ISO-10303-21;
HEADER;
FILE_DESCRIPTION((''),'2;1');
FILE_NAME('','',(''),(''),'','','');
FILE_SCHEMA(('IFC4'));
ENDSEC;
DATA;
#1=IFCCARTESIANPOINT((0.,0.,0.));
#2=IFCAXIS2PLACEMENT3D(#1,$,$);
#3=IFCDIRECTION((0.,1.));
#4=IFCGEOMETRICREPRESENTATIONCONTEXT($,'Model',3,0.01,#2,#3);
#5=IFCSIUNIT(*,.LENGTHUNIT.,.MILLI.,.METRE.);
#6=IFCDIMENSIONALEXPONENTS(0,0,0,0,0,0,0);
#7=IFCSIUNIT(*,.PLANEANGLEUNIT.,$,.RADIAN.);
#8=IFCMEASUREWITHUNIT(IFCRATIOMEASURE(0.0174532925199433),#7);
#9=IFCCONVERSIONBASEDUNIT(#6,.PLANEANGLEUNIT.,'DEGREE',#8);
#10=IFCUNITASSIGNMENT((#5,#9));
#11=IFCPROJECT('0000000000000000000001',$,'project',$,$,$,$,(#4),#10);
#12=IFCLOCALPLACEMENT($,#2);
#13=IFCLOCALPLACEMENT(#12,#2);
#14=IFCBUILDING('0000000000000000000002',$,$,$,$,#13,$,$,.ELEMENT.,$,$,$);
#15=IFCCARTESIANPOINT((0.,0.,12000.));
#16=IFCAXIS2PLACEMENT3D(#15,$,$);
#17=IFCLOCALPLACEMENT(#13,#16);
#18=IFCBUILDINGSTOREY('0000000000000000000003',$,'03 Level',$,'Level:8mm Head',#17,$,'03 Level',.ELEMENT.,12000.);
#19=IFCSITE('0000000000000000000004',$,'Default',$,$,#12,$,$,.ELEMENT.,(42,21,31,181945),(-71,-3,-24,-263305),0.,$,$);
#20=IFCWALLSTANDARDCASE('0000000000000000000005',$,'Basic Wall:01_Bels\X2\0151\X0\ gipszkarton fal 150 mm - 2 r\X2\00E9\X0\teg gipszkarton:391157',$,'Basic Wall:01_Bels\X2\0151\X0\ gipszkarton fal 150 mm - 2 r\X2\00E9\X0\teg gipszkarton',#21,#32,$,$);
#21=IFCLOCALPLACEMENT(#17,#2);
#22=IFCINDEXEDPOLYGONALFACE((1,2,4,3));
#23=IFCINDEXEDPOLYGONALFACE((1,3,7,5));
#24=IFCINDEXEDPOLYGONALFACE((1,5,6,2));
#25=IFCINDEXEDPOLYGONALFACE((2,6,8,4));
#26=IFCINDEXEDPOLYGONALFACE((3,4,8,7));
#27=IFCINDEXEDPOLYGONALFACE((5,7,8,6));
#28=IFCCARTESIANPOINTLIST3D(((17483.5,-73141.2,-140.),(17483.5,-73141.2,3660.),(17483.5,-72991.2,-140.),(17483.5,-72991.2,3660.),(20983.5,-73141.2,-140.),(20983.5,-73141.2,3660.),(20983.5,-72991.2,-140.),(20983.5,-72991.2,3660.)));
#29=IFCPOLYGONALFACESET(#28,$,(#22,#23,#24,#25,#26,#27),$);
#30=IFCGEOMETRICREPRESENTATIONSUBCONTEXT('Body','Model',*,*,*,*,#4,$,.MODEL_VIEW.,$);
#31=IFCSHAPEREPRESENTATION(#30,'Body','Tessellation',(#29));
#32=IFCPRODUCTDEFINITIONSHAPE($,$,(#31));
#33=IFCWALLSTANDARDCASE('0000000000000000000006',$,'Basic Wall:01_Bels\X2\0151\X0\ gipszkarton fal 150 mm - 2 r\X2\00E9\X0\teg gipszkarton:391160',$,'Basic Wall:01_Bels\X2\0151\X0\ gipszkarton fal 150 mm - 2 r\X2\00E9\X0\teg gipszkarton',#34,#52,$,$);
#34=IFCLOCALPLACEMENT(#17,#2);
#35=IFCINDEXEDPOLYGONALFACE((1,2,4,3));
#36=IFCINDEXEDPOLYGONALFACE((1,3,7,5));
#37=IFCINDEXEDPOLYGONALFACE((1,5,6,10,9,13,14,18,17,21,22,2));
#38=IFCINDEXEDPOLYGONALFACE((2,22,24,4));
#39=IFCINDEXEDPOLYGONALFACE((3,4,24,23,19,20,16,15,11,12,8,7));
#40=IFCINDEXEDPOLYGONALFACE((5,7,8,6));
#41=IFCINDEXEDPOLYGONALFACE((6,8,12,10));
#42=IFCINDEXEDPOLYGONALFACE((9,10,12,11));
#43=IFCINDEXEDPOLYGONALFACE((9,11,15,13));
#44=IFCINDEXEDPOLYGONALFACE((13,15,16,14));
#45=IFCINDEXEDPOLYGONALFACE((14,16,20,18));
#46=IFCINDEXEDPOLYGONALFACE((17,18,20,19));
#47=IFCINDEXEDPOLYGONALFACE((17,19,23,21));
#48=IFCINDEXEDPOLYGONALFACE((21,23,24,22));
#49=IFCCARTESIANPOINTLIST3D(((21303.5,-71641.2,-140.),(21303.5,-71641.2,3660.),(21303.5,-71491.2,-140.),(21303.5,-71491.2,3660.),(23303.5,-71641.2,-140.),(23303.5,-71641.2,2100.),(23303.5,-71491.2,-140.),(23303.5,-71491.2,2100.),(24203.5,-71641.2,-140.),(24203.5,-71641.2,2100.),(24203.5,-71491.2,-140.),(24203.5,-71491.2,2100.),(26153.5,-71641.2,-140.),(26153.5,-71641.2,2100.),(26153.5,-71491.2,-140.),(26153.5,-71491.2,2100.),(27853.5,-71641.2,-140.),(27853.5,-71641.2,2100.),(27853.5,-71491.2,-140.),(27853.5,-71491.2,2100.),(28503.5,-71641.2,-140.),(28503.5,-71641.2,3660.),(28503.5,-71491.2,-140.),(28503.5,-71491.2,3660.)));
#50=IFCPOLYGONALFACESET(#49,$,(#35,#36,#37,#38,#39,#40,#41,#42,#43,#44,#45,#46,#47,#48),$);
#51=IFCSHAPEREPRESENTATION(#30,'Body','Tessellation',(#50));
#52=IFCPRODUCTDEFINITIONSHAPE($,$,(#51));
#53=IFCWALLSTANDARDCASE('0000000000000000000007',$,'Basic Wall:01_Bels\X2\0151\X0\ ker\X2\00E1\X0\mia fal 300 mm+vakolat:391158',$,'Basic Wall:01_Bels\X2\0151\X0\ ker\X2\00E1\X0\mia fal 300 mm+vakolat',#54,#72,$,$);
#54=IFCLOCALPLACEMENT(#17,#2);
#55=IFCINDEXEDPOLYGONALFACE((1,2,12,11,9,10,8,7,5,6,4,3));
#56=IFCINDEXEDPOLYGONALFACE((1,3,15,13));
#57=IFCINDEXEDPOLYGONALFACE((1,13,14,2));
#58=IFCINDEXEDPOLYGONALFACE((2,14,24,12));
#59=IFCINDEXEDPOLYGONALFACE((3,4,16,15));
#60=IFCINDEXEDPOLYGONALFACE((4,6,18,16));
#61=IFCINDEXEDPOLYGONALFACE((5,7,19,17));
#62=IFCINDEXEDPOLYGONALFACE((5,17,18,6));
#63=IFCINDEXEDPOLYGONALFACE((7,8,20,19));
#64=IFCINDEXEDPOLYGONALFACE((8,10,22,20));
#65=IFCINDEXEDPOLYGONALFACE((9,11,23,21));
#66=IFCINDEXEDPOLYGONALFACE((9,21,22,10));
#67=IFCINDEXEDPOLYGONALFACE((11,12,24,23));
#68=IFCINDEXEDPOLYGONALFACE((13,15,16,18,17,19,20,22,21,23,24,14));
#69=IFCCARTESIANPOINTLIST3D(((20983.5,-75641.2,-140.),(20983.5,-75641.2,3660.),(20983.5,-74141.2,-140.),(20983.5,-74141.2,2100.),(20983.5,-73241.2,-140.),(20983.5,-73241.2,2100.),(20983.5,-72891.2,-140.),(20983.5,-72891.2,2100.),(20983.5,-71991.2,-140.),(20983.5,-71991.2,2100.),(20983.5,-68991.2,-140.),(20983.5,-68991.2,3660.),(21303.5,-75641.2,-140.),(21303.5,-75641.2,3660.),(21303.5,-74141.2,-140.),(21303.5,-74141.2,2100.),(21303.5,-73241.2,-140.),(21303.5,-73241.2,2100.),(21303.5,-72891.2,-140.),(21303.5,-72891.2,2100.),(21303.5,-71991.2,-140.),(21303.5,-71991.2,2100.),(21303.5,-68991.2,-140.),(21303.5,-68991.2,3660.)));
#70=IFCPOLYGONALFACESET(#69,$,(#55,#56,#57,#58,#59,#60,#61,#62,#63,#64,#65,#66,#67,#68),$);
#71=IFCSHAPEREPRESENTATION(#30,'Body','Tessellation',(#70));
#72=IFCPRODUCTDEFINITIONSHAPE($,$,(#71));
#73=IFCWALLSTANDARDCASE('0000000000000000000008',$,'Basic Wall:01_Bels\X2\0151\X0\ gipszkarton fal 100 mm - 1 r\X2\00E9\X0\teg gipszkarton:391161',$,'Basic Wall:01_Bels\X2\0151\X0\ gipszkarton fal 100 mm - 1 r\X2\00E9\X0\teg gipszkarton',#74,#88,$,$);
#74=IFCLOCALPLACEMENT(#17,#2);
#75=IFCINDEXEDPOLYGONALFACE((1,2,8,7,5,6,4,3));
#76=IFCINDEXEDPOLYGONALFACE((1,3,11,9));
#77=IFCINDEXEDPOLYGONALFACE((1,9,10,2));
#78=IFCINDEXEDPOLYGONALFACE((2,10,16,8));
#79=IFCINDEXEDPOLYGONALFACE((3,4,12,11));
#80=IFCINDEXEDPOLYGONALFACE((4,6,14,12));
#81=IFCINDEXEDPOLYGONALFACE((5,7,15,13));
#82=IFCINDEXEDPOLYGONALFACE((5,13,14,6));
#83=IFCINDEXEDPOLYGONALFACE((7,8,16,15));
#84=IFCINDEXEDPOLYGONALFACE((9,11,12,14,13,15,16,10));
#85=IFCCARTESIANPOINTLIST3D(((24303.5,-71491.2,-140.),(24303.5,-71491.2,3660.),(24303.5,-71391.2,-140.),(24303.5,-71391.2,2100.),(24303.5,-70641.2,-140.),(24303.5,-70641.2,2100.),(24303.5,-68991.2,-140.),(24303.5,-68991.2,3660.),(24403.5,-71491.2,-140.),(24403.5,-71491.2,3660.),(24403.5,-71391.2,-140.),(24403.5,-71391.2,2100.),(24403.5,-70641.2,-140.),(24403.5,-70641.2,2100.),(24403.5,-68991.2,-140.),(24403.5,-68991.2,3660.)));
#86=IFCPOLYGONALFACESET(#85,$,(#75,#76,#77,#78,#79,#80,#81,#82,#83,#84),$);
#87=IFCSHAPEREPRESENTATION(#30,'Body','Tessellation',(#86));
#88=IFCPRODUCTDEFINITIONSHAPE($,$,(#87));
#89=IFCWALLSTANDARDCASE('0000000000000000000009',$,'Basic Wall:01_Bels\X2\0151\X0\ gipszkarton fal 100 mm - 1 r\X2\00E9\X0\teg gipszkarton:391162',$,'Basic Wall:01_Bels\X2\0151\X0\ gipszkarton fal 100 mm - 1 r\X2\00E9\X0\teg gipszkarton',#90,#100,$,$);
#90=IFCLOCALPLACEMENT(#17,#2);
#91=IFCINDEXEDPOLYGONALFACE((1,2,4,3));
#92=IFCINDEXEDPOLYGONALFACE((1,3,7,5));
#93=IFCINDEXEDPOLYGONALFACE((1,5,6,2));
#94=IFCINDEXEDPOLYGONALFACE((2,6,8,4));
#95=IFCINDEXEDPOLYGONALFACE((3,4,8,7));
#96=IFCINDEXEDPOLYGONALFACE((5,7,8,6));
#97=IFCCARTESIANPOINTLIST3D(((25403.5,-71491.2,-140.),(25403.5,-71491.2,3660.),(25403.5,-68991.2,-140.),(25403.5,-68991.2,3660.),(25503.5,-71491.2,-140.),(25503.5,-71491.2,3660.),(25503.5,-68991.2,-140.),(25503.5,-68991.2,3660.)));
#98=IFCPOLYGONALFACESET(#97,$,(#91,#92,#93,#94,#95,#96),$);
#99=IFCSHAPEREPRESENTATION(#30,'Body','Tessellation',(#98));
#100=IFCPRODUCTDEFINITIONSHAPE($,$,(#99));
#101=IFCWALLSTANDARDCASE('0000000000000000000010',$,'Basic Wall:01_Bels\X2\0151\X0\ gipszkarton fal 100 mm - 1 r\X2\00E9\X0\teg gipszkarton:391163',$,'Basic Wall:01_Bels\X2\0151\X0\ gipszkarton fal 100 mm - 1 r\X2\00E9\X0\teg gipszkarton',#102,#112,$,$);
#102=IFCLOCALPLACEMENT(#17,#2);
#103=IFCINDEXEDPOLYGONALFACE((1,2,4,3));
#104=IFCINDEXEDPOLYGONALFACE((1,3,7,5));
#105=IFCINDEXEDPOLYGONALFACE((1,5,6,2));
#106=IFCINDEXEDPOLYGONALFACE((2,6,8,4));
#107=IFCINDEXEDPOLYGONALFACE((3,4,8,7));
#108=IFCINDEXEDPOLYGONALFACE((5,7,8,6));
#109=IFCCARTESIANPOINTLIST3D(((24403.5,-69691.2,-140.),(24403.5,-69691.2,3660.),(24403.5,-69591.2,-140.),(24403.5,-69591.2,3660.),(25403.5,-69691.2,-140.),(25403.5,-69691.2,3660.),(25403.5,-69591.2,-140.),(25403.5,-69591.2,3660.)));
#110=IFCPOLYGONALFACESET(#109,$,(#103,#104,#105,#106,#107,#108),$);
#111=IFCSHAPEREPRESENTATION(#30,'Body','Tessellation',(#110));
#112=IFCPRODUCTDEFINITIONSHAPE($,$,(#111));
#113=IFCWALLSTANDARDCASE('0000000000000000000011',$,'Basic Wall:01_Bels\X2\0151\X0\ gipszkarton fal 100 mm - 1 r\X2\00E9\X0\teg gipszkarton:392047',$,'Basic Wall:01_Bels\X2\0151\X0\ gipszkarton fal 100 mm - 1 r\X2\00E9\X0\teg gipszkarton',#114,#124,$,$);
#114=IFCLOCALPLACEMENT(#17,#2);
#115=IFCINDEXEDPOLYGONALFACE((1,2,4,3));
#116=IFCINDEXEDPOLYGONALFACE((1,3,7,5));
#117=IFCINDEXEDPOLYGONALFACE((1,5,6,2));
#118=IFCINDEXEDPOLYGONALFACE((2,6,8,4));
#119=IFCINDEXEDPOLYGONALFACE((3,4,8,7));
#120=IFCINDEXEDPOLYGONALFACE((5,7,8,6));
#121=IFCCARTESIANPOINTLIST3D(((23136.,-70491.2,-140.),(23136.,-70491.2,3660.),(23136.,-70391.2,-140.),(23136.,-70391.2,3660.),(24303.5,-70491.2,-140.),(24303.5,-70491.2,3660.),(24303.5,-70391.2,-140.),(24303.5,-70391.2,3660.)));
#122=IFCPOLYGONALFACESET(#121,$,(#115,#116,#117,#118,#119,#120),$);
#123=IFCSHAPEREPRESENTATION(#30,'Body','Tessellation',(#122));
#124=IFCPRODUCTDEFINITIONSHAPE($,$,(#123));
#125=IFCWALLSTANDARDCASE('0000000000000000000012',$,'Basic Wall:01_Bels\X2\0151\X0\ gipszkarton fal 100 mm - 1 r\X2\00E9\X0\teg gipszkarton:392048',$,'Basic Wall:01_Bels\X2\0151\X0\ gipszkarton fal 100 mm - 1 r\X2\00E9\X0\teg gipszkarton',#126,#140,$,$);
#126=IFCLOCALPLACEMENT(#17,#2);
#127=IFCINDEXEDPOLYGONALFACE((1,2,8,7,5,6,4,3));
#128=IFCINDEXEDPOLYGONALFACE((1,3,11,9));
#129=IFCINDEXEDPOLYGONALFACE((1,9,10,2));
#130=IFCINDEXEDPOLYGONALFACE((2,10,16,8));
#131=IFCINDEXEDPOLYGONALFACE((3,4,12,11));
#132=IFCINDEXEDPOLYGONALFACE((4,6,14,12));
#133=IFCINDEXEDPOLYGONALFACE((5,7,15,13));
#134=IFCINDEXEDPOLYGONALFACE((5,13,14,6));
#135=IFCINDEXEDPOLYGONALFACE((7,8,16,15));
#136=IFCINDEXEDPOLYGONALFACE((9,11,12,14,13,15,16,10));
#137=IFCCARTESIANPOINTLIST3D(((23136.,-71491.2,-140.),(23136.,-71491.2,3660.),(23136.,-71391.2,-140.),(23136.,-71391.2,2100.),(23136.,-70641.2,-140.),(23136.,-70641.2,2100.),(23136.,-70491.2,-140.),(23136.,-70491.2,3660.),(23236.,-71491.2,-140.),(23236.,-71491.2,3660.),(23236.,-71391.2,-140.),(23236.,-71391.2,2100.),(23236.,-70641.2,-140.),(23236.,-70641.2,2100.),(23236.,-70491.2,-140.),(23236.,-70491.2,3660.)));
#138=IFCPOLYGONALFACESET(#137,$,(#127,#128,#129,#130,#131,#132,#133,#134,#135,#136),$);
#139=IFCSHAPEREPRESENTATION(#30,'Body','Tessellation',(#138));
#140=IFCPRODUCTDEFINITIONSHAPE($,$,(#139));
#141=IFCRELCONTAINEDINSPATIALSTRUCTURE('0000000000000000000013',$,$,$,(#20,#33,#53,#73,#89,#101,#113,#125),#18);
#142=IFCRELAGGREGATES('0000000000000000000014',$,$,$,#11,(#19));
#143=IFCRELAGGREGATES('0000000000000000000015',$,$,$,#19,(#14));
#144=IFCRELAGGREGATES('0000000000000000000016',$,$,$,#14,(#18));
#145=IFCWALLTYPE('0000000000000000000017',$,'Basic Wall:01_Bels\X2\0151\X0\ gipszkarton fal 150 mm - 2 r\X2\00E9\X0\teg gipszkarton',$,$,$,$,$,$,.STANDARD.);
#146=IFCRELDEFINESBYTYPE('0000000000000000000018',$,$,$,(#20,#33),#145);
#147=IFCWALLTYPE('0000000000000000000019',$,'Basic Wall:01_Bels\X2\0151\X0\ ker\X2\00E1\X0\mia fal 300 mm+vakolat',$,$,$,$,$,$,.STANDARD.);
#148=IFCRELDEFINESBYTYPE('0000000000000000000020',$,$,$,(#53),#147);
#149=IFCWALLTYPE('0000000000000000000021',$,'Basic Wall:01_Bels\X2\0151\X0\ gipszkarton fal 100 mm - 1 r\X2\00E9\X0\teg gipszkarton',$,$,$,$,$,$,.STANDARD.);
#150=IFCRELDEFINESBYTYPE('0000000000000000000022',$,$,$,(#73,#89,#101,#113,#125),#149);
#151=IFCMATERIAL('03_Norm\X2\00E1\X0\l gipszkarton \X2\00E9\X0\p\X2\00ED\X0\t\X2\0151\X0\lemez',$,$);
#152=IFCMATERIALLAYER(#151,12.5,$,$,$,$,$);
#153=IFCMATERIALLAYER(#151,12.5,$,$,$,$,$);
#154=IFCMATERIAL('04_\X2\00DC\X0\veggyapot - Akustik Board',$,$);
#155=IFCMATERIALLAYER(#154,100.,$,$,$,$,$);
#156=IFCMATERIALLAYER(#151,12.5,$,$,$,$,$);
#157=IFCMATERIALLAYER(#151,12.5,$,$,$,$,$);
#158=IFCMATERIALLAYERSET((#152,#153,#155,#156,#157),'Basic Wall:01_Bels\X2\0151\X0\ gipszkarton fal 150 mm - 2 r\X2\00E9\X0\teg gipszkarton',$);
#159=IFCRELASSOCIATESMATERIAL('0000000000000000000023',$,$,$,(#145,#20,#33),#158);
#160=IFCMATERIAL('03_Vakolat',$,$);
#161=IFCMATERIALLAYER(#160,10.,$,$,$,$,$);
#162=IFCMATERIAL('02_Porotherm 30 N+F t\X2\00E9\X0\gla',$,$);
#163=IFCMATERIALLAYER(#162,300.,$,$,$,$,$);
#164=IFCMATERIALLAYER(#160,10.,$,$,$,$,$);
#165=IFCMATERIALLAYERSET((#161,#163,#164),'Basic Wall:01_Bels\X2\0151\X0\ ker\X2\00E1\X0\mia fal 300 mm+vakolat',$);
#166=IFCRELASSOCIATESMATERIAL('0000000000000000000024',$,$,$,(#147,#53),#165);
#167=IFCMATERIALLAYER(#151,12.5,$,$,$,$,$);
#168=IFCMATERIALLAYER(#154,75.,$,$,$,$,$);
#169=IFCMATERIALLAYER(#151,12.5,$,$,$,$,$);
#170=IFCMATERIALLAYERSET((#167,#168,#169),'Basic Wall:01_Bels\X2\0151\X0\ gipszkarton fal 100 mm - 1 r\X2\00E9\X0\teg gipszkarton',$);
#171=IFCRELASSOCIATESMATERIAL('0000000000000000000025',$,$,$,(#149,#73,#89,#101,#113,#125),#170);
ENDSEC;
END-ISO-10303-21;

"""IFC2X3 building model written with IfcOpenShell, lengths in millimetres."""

from ifc_helpers import new_model, entity, si_unit, converted_unit, direction, frame, frame_2d, origin, place, context, subcontext, project, spatial, rectangle, extrude, material, layer, layer_set, layer_usage, type_object, element, save


model = new_model("IFC2X3")

# Units and contexts
model_context = context("Model", 3, precision=0.01, world=origin(), true_north=direction((0.0, 1.0)))
body_context = subcontext(model_context, "Body", "Model", "MODEL_VIEW")
ifc_project = project(units=[si_unit("LENGTHUNIT", "METRE", prefix="MILLI"), converted_unit("PLANEANGLEUNIT", "DEGREE", entity("IfcRatioMeasure", 0.0174532925199433), si_unit("PLANEANGLEUNIT", "RADIAN"), dimensions=[0, 0, 0, 0, 0, 0, 0])], contexts=[model_context])

# Site, building, storey
site_placement = place(None, origin())
site = spatial("IfcSite", under=ifc_project, at=site_placement, Name="Default", CompositionType="ELEMENT", RefLatitude=(42, 21, 31, 181945), RefLongitude=(-71, -3, -24, -263305), RefElevation=0.0)
building_placement = place(site_placement, origin())
building = spatial("IfcBuilding", under=site, at=building_placement, CompositionType="ELEMENT")
storey_placement = place(building_placement, frame((0.0, 0.0, 12000.0)))
storey = spatial("IfcBuildingStorey", under=building, at=storey_placement, Name="03 Level", ObjectType="Level:8mm Head", LongName="03 Level", CompositionType="ELEMENT", Elevation=12000.0)

# Wall
ifc_material_1 = material(Name="03_Normál gipszkarton építőlemez")
ifc_layer_1 = layer(ifc_material_1, 12.5)
ifc_layer_2 = layer(ifc_material_1, 12.5)
ifc_material_2 = material(Name="04_Üveggyapot - Akustik Board")
ifc_layer_3 = layer(ifc_material_2, 100.0)
ifc_layer_4 = layer(ifc_material_1, 12.5)
ifc_layer_5 = layer(ifc_material_1, 12.5)
ifc_layer_set_1 = layer_set([ifc_layer_1, ifc_layer_2, ifc_layer_3, ifc_layer_4, ifc_layer_5], Name="Basic Wall:01_Belső gipszkarton fal 150 mm - 2 réteg gipszkarton")
ifc_layer_usage_1 = layer_usage(ifc_layer_set_1, "AXIS2", "NEGATIVE", 75.0)
wall_type_1 = type_object("IfcWallType", Name="Basic Wall:01_Belső gipszkarton fal 150 mm - 2 réteg gipszkarton", PredefinedType="STANDARD", material=ifc_layer_set_1)
wall_1_placement = place(storey_placement, frame((17483.5, -73066.2, -140.0)))
element("IfcWallStandardCase", 1, at=wall_1_placement, inside=storey, type_object=wall_type_1, material=ifc_layer_usage_1, Name="Basic Wall:01_Belső gipszkarton fal 150 mm - 2 réteg gipszkarton:391157", ObjectType="Basic Wall:01_Belső gipszkarton fal 150 mm - 2 réteg gipszkarton", context=body_context, shape_type="SweptSolid", body=[
    extrude(rectangle(XDim=3500.0, YDim=150.0, at=frame_2d((1750.0, 0.0), x_axis=(-1.0, 0.0))), origin(), (0.0, 0.0, 1.0), 3800.0),
])

# Walls, openings
ifc_layer_usage_2 = layer_usage(ifc_layer_set_1, "AXIS2", "NEGATIVE", 75.0)
wall_2_placement = place(storey_placement, frame((21303.5, -71566.2, -140.0)))
wall_2 = element("IfcWallStandardCase", 2, at=wall_2_placement, inside=storey, type_object=wall_type_1, material=ifc_layer_usage_2, Name="Basic Wall:01_Belső gipszkarton fal 150 mm - 2 réteg gipszkarton:391160", ObjectType="Basic Wall:01_Belső gipszkarton fal 150 mm - 2 réteg gipszkarton", context=body_context, shape_type="SweptSolid", body=[
    extrude(rectangle(XDim=7200.0, YDim=150.0, at=frame_2d((3600.0, 0.0), x_axis=(-1.0, 0.0))), origin(), (0.0, 0.0, 1.0), 3800.0),
])
opening_1_placement = place(wall_2_placement, frame((4850.0, -75.0, 0.0)))
element("IfcOpeningElement", 3, at=opening_1_placement, cuts=wall_2, ObjectType="Opening", context=body_context, shape_type="SweptSolid", body=[
    extrude(rectangle(XDim=2240.0, YDim=1700.0, at=frame_2d((0.0, 0.0), x_axis=(1.0, 0.0))), frame((850.0, 0.0, 1120.0), z_axis=(0.0, 1.0, 0.0), x_axis=(0.0, 0.0, -1.0)), (0.0, 0.0, 1.0), 150.0),
])
opening_2_placement = place(wall_2_placement, frame((2000.0, -1449.0, 0.0)))
element("IfcOpeningElement", 4, at=opening_2_placement, cuts=wall_2, ObjectType="Opening", context=body_context, shape_type="SweptSolid", body=[
    extrude(rectangle(XDim=2240.0, YDim=900.0, at=frame_2d((0.0, 0.0), x_axis=(0.0, 1.0))), frame((450.0, 0.0, 1120.0), z_axis=(0.0, 1.0, 0.0), x_axis=(-1.0, 0.0, 0.0)), (0.0, 0.0, 1.0), 3048.0),
])
ifc_material_3 = material(Name="03_Vakolat")
ifc_layer_6 = layer(ifc_material_3, 10.0)
ifc_material_4 = material(Name="02_Porotherm 30 N+F tégla")
ifc_layer_7 = layer(ifc_material_4, 300.0)
ifc_layer_8 = layer(ifc_material_3, 10.0)
ifc_layer_set_2 = layer_set([ifc_layer_6, ifc_layer_7, ifc_layer_8], Name="Basic Wall:01_Belső kerámia fal 300 mm+vakolat")
ifc_layer_usage_3 = layer_usage(ifc_layer_set_2, "AXIS2", "NEGATIVE", 160.0)
wall_type_2 = type_object("IfcWallType", Name="Basic Wall:01_Belső kerámia fal 300 mm+vakolat", PredefinedType="STANDARD", material=ifc_layer_set_2)
wall_3_placement = place(storey_placement, frame((21143.5, -68991.2, -140.0), z_axis=(0.0, 0.0, 1.0), x_axis=(0.0, -1.0, 0.0)))
wall_3 = element("IfcWallStandardCase", 5, at=wall_3_placement, inside=storey, type_object=wall_type_2, material=ifc_layer_usage_3, Name="Basic Wall:01_Belső kerámia fal 300 mm+vakolat:391158", ObjectType="Basic Wall:01_Belső kerámia fal 300 mm+vakolat", context=body_context, shape_type="SweptSolid", body=[
    extrude(rectangle(XDim=6650.0, YDim=320.0, at=frame_2d((3325.0, 0.0), x_axis=(-1.0, 0.0))), origin(), (0.0, 0.0, 1.0), 3800.0),
])
opening_3_placement = place(wall_3_placement, frame((3900.0, -1364.0, 0.0), z_axis=(0.0, 0.0, 1.0), x_axis=(0.0, 1.0, 0.0)))
element("IfcOpeningElement", 6, at=opening_3_placement, cuts=wall_3, ObjectType="Opening", context=body_context, shape_type="SweptSolid", body=[
    extrude(rectangle(XDim=2240.0, YDim=900.0, at=frame_2d((0.0, 0.0), x_axis=(1.0, 0.0))), frame((0.0, 450.0, 1120.0), z_axis=(1.0, 0.0, 0.0), x_axis=(0.0, 0.0, 1.0)), (0.0, 0.0, 1.0), 3048.0),
])
opening_4_placement = place(wall_3_placement, frame((5150.0, -1364.0, 0.0), z_axis=(0.0, 0.0, 1.0), x_axis=(0.0, 1.0, 0.0)))
element("IfcOpeningElement", 7, at=opening_4_placement, cuts=wall_3, ObjectType="Opening", context=body_context, shape_type="SweptSolid", body=[
    extrude(rectangle(XDim=2240.0, YDim=900.0, at=frame_2d((0.0, 0.0), x_axis=(0.0, 1.0))), frame((0.0, 450.0, 1120.0), z_axis=(1.0, 0.0, 0.0), x_axis=(0.0, 1.0, 0.0)), (0.0, 0.0, 1.0), 3048.0),
])

# Wall, opening
ifc_layer_9 = layer(ifc_material_1, 12.5)
ifc_layer_10 = layer(ifc_material_2, 75.0)
ifc_layer_11 = layer(ifc_material_1, 12.5)
ifc_layer_set_3 = layer_set([ifc_layer_9, ifc_layer_10, ifc_layer_11], Name="Basic Wall:01_Belső gipszkarton fal 100 mm - 1 réteg gipszkarton")
ifc_layer_usage_4 = layer_usage(ifc_layer_set_3, "AXIS2", "NEGATIVE", 50.0)
wall_type_3 = type_object("IfcWallType", Name="Basic Wall:01_Belső gipszkarton fal 100 mm - 1 réteg gipszkarton", PredefinedType="STANDARD", material=ifc_layer_set_3)
wall_4_placement = place(storey_placement, frame((24353.5, -71491.2, -140.0), z_axis=(0.0, 0.0, 1.0), x_axis=(0.0, 1.0, 0.0)))
wall_4 = element("IfcWallStandardCase", 8, at=wall_4_placement, inside=storey, type_object=wall_type_3, material=ifc_layer_usage_4, Name="Basic Wall:01_Belső gipszkarton fal 100 mm - 1 réteg gipszkarton:391161", ObjectType="Basic Wall:01_Belső gipszkarton fal 100 mm - 1 réteg gipszkarton", context=body_context, shape_type="SweptSolid", body=[
    extrude(rectangle(XDim=2500.0, YDim=100.0, at=frame_2d((1250.0, 0.0), x_axis=(-1.0, 0.0))), origin(), (0.0, 0.0, 1.0), 3800.0),
])
opening_5_placement = place(wall_4_placement, frame((100.0, 1574.0, 0.0), z_axis=(0.0, 0.0, 1.0), x_axis=(0.0, -1.0, 0.0)))
element("IfcOpeningElement", 9, at=opening_5_placement, cuts=wall_4, ObjectType="Opening", context=body_context, shape_type="SweptSolid", body=[
    extrude(rectangle(XDim=2240.0, YDim=750.0, at=frame_2d((0.0, 0.0), x_axis=(0.0, 1.0))), frame((3048.0, 375.0, 1120.0), z_axis=(-1.0, 0.0, 0.0), x_axis=(0.0, -1.0, 0.0)), (0.0, 0.0, 1.0), 3048.0),
])

# Walls
ifc_layer_usage_5 = layer_usage(ifc_layer_set_3, "AXIS2", "NEGATIVE", 50.0)
wall_5_placement = place(storey_placement, frame((25453.5, -71491.2, -140.0), z_axis=(0.0, 0.0, 1.0), x_axis=(0.0, 1.0, 0.0)))
element("IfcWallStandardCase", 10, at=wall_5_placement, inside=storey, type_object=wall_type_3, material=ifc_layer_usage_5, Name="Basic Wall:01_Belső gipszkarton fal 100 mm - 1 réteg gipszkarton:391162", ObjectType="Basic Wall:01_Belső gipszkarton fal 100 mm - 1 réteg gipszkarton", context=body_context, shape_type="SweptSolid", body=[
    extrude(rectangle(XDim=2500.0, YDim=100.0, at=frame_2d((1250.0, 0.0), x_axis=(-1.0, 0.0))), origin(), (0.0, 0.0, 1.0), 3800.0),
])
ifc_layer_usage_6 = layer_usage(ifc_layer_set_3, "AXIS2", "NEGATIVE", 50.0)
wall_6_placement = place(storey_placement, frame((24403.5, -69641.2, -140.0)))
element("IfcWallStandardCase", 11, at=wall_6_placement, inside=storey, type_object=wall_type_3, material=ifc_layer_usage_6, Name="Basic Wall:01_Belső gipszkarton fal 100 mm - 1 réteg gipszkarton:391163", ObjectType="Basic Wall:01_Belső gipszkarton fal 100 mm - 1 réteg gipszkarton", context=body_context, shape_type="SweptSolid", body=[
    extrude(rectangle(XDim=1000.0, YDim=100.0, at=frame_2d((500.0, 0.0), x_axis=(-1.0, 0.0))), origin(), (0.0, 0.0, 1.0), 3800.0),
])
ifc_layer_usage_7 = layer_usage(ifc_layer_set_3, "AXIS2", "NEGATIVE", 50.0)
wall_7_placement = place(storey_placement, frame((24303.5, -70441.2, -140.0), z_axis=(0.0, 0.0, 1.0), x_axis=(-1.0, 0.0, 0.0)))
element("IfcWallStandardCase", 12, at=wall_7_placement, inside=storey, type_object=wall_type_3, material=ifc_layer_usage_7, Name="Basic Wall:01_Belső gipszkarton fal 100 mm - 1 réteg gipszkarton:392047", ObjectType="Basic Wall:01_Belső gipszkarton fal 100 mm - 1 réteg gipszkarton", context=body_context, shape_type="SweptSolid", body=[
    extrude(rectangle(XDim=1167.5, YDim=100.0, at=frame_2d((583.7, 0.0), x_axis=(-1.0, 0.0))), origin(), (0.0, 0.0, 1.0), 3800.0),
])

# Wall, opening
ifc_layer_usage_8 = layer_usage(ifc_layer_set_3, "AXIS2", "NEGATIVE", 50.0)
wall_8_placement = place(storey_placement, frame((23186.0, -70491.2, -140.0), z_axis=(0.0, 0.0, 1.0), x_axis=(0.0, -1.0, 0.0)))
wall_8 = element("IfcWallStandardCase", 13, at=wall_8_placement, inside=storey, type_object=wall_type_3, material=ifc_layer_usage_8, Name="Basic Wall:01_Belső gipszkarton fal 100 mm - 1 réteg gipszkarton:392048", ObjectType="Basic Wall:01_Belső gipszkarton fal 100 mm - 1 réteg gipszkarton", context=body_context, shape_type="SweptSolid", body=[
    extrude(rectangle(XDim=1000.0, YDim=100.0, at=frame_2d((500.0, 0.0), x_axis=(-1.0, 0.0))), origin(), (0.0, 0.0, 1.0), 3800.0),
])
opening_6_placement = place(wall_8_placement, frame((900.0, -1474.0, 0.0), z_axis=(0.0, 0.0, 1.0), x_axis=(0.0, 1.0, 0.0)))
element("IfcOpeningElement", 14, at=opening_6_placement, cuts=wall_8, ObjectType="Opening", context=body_context, shape_type="SweptSolid", body=[
    extrude(rectangle(XDim=2240.0, YDim=750.0, at=frame_2d((0.0, 0.0), x_axis=(1.0, 0.0))), frame((0.0, 375.0, 1120.0), z_axis=(1.0, 0.0, 0.0), x_axis=(0.0, 0.0, 1.0)), (0.0, 0.0, 1.0), 3048.0),
])

save(model, "model.ifc")
